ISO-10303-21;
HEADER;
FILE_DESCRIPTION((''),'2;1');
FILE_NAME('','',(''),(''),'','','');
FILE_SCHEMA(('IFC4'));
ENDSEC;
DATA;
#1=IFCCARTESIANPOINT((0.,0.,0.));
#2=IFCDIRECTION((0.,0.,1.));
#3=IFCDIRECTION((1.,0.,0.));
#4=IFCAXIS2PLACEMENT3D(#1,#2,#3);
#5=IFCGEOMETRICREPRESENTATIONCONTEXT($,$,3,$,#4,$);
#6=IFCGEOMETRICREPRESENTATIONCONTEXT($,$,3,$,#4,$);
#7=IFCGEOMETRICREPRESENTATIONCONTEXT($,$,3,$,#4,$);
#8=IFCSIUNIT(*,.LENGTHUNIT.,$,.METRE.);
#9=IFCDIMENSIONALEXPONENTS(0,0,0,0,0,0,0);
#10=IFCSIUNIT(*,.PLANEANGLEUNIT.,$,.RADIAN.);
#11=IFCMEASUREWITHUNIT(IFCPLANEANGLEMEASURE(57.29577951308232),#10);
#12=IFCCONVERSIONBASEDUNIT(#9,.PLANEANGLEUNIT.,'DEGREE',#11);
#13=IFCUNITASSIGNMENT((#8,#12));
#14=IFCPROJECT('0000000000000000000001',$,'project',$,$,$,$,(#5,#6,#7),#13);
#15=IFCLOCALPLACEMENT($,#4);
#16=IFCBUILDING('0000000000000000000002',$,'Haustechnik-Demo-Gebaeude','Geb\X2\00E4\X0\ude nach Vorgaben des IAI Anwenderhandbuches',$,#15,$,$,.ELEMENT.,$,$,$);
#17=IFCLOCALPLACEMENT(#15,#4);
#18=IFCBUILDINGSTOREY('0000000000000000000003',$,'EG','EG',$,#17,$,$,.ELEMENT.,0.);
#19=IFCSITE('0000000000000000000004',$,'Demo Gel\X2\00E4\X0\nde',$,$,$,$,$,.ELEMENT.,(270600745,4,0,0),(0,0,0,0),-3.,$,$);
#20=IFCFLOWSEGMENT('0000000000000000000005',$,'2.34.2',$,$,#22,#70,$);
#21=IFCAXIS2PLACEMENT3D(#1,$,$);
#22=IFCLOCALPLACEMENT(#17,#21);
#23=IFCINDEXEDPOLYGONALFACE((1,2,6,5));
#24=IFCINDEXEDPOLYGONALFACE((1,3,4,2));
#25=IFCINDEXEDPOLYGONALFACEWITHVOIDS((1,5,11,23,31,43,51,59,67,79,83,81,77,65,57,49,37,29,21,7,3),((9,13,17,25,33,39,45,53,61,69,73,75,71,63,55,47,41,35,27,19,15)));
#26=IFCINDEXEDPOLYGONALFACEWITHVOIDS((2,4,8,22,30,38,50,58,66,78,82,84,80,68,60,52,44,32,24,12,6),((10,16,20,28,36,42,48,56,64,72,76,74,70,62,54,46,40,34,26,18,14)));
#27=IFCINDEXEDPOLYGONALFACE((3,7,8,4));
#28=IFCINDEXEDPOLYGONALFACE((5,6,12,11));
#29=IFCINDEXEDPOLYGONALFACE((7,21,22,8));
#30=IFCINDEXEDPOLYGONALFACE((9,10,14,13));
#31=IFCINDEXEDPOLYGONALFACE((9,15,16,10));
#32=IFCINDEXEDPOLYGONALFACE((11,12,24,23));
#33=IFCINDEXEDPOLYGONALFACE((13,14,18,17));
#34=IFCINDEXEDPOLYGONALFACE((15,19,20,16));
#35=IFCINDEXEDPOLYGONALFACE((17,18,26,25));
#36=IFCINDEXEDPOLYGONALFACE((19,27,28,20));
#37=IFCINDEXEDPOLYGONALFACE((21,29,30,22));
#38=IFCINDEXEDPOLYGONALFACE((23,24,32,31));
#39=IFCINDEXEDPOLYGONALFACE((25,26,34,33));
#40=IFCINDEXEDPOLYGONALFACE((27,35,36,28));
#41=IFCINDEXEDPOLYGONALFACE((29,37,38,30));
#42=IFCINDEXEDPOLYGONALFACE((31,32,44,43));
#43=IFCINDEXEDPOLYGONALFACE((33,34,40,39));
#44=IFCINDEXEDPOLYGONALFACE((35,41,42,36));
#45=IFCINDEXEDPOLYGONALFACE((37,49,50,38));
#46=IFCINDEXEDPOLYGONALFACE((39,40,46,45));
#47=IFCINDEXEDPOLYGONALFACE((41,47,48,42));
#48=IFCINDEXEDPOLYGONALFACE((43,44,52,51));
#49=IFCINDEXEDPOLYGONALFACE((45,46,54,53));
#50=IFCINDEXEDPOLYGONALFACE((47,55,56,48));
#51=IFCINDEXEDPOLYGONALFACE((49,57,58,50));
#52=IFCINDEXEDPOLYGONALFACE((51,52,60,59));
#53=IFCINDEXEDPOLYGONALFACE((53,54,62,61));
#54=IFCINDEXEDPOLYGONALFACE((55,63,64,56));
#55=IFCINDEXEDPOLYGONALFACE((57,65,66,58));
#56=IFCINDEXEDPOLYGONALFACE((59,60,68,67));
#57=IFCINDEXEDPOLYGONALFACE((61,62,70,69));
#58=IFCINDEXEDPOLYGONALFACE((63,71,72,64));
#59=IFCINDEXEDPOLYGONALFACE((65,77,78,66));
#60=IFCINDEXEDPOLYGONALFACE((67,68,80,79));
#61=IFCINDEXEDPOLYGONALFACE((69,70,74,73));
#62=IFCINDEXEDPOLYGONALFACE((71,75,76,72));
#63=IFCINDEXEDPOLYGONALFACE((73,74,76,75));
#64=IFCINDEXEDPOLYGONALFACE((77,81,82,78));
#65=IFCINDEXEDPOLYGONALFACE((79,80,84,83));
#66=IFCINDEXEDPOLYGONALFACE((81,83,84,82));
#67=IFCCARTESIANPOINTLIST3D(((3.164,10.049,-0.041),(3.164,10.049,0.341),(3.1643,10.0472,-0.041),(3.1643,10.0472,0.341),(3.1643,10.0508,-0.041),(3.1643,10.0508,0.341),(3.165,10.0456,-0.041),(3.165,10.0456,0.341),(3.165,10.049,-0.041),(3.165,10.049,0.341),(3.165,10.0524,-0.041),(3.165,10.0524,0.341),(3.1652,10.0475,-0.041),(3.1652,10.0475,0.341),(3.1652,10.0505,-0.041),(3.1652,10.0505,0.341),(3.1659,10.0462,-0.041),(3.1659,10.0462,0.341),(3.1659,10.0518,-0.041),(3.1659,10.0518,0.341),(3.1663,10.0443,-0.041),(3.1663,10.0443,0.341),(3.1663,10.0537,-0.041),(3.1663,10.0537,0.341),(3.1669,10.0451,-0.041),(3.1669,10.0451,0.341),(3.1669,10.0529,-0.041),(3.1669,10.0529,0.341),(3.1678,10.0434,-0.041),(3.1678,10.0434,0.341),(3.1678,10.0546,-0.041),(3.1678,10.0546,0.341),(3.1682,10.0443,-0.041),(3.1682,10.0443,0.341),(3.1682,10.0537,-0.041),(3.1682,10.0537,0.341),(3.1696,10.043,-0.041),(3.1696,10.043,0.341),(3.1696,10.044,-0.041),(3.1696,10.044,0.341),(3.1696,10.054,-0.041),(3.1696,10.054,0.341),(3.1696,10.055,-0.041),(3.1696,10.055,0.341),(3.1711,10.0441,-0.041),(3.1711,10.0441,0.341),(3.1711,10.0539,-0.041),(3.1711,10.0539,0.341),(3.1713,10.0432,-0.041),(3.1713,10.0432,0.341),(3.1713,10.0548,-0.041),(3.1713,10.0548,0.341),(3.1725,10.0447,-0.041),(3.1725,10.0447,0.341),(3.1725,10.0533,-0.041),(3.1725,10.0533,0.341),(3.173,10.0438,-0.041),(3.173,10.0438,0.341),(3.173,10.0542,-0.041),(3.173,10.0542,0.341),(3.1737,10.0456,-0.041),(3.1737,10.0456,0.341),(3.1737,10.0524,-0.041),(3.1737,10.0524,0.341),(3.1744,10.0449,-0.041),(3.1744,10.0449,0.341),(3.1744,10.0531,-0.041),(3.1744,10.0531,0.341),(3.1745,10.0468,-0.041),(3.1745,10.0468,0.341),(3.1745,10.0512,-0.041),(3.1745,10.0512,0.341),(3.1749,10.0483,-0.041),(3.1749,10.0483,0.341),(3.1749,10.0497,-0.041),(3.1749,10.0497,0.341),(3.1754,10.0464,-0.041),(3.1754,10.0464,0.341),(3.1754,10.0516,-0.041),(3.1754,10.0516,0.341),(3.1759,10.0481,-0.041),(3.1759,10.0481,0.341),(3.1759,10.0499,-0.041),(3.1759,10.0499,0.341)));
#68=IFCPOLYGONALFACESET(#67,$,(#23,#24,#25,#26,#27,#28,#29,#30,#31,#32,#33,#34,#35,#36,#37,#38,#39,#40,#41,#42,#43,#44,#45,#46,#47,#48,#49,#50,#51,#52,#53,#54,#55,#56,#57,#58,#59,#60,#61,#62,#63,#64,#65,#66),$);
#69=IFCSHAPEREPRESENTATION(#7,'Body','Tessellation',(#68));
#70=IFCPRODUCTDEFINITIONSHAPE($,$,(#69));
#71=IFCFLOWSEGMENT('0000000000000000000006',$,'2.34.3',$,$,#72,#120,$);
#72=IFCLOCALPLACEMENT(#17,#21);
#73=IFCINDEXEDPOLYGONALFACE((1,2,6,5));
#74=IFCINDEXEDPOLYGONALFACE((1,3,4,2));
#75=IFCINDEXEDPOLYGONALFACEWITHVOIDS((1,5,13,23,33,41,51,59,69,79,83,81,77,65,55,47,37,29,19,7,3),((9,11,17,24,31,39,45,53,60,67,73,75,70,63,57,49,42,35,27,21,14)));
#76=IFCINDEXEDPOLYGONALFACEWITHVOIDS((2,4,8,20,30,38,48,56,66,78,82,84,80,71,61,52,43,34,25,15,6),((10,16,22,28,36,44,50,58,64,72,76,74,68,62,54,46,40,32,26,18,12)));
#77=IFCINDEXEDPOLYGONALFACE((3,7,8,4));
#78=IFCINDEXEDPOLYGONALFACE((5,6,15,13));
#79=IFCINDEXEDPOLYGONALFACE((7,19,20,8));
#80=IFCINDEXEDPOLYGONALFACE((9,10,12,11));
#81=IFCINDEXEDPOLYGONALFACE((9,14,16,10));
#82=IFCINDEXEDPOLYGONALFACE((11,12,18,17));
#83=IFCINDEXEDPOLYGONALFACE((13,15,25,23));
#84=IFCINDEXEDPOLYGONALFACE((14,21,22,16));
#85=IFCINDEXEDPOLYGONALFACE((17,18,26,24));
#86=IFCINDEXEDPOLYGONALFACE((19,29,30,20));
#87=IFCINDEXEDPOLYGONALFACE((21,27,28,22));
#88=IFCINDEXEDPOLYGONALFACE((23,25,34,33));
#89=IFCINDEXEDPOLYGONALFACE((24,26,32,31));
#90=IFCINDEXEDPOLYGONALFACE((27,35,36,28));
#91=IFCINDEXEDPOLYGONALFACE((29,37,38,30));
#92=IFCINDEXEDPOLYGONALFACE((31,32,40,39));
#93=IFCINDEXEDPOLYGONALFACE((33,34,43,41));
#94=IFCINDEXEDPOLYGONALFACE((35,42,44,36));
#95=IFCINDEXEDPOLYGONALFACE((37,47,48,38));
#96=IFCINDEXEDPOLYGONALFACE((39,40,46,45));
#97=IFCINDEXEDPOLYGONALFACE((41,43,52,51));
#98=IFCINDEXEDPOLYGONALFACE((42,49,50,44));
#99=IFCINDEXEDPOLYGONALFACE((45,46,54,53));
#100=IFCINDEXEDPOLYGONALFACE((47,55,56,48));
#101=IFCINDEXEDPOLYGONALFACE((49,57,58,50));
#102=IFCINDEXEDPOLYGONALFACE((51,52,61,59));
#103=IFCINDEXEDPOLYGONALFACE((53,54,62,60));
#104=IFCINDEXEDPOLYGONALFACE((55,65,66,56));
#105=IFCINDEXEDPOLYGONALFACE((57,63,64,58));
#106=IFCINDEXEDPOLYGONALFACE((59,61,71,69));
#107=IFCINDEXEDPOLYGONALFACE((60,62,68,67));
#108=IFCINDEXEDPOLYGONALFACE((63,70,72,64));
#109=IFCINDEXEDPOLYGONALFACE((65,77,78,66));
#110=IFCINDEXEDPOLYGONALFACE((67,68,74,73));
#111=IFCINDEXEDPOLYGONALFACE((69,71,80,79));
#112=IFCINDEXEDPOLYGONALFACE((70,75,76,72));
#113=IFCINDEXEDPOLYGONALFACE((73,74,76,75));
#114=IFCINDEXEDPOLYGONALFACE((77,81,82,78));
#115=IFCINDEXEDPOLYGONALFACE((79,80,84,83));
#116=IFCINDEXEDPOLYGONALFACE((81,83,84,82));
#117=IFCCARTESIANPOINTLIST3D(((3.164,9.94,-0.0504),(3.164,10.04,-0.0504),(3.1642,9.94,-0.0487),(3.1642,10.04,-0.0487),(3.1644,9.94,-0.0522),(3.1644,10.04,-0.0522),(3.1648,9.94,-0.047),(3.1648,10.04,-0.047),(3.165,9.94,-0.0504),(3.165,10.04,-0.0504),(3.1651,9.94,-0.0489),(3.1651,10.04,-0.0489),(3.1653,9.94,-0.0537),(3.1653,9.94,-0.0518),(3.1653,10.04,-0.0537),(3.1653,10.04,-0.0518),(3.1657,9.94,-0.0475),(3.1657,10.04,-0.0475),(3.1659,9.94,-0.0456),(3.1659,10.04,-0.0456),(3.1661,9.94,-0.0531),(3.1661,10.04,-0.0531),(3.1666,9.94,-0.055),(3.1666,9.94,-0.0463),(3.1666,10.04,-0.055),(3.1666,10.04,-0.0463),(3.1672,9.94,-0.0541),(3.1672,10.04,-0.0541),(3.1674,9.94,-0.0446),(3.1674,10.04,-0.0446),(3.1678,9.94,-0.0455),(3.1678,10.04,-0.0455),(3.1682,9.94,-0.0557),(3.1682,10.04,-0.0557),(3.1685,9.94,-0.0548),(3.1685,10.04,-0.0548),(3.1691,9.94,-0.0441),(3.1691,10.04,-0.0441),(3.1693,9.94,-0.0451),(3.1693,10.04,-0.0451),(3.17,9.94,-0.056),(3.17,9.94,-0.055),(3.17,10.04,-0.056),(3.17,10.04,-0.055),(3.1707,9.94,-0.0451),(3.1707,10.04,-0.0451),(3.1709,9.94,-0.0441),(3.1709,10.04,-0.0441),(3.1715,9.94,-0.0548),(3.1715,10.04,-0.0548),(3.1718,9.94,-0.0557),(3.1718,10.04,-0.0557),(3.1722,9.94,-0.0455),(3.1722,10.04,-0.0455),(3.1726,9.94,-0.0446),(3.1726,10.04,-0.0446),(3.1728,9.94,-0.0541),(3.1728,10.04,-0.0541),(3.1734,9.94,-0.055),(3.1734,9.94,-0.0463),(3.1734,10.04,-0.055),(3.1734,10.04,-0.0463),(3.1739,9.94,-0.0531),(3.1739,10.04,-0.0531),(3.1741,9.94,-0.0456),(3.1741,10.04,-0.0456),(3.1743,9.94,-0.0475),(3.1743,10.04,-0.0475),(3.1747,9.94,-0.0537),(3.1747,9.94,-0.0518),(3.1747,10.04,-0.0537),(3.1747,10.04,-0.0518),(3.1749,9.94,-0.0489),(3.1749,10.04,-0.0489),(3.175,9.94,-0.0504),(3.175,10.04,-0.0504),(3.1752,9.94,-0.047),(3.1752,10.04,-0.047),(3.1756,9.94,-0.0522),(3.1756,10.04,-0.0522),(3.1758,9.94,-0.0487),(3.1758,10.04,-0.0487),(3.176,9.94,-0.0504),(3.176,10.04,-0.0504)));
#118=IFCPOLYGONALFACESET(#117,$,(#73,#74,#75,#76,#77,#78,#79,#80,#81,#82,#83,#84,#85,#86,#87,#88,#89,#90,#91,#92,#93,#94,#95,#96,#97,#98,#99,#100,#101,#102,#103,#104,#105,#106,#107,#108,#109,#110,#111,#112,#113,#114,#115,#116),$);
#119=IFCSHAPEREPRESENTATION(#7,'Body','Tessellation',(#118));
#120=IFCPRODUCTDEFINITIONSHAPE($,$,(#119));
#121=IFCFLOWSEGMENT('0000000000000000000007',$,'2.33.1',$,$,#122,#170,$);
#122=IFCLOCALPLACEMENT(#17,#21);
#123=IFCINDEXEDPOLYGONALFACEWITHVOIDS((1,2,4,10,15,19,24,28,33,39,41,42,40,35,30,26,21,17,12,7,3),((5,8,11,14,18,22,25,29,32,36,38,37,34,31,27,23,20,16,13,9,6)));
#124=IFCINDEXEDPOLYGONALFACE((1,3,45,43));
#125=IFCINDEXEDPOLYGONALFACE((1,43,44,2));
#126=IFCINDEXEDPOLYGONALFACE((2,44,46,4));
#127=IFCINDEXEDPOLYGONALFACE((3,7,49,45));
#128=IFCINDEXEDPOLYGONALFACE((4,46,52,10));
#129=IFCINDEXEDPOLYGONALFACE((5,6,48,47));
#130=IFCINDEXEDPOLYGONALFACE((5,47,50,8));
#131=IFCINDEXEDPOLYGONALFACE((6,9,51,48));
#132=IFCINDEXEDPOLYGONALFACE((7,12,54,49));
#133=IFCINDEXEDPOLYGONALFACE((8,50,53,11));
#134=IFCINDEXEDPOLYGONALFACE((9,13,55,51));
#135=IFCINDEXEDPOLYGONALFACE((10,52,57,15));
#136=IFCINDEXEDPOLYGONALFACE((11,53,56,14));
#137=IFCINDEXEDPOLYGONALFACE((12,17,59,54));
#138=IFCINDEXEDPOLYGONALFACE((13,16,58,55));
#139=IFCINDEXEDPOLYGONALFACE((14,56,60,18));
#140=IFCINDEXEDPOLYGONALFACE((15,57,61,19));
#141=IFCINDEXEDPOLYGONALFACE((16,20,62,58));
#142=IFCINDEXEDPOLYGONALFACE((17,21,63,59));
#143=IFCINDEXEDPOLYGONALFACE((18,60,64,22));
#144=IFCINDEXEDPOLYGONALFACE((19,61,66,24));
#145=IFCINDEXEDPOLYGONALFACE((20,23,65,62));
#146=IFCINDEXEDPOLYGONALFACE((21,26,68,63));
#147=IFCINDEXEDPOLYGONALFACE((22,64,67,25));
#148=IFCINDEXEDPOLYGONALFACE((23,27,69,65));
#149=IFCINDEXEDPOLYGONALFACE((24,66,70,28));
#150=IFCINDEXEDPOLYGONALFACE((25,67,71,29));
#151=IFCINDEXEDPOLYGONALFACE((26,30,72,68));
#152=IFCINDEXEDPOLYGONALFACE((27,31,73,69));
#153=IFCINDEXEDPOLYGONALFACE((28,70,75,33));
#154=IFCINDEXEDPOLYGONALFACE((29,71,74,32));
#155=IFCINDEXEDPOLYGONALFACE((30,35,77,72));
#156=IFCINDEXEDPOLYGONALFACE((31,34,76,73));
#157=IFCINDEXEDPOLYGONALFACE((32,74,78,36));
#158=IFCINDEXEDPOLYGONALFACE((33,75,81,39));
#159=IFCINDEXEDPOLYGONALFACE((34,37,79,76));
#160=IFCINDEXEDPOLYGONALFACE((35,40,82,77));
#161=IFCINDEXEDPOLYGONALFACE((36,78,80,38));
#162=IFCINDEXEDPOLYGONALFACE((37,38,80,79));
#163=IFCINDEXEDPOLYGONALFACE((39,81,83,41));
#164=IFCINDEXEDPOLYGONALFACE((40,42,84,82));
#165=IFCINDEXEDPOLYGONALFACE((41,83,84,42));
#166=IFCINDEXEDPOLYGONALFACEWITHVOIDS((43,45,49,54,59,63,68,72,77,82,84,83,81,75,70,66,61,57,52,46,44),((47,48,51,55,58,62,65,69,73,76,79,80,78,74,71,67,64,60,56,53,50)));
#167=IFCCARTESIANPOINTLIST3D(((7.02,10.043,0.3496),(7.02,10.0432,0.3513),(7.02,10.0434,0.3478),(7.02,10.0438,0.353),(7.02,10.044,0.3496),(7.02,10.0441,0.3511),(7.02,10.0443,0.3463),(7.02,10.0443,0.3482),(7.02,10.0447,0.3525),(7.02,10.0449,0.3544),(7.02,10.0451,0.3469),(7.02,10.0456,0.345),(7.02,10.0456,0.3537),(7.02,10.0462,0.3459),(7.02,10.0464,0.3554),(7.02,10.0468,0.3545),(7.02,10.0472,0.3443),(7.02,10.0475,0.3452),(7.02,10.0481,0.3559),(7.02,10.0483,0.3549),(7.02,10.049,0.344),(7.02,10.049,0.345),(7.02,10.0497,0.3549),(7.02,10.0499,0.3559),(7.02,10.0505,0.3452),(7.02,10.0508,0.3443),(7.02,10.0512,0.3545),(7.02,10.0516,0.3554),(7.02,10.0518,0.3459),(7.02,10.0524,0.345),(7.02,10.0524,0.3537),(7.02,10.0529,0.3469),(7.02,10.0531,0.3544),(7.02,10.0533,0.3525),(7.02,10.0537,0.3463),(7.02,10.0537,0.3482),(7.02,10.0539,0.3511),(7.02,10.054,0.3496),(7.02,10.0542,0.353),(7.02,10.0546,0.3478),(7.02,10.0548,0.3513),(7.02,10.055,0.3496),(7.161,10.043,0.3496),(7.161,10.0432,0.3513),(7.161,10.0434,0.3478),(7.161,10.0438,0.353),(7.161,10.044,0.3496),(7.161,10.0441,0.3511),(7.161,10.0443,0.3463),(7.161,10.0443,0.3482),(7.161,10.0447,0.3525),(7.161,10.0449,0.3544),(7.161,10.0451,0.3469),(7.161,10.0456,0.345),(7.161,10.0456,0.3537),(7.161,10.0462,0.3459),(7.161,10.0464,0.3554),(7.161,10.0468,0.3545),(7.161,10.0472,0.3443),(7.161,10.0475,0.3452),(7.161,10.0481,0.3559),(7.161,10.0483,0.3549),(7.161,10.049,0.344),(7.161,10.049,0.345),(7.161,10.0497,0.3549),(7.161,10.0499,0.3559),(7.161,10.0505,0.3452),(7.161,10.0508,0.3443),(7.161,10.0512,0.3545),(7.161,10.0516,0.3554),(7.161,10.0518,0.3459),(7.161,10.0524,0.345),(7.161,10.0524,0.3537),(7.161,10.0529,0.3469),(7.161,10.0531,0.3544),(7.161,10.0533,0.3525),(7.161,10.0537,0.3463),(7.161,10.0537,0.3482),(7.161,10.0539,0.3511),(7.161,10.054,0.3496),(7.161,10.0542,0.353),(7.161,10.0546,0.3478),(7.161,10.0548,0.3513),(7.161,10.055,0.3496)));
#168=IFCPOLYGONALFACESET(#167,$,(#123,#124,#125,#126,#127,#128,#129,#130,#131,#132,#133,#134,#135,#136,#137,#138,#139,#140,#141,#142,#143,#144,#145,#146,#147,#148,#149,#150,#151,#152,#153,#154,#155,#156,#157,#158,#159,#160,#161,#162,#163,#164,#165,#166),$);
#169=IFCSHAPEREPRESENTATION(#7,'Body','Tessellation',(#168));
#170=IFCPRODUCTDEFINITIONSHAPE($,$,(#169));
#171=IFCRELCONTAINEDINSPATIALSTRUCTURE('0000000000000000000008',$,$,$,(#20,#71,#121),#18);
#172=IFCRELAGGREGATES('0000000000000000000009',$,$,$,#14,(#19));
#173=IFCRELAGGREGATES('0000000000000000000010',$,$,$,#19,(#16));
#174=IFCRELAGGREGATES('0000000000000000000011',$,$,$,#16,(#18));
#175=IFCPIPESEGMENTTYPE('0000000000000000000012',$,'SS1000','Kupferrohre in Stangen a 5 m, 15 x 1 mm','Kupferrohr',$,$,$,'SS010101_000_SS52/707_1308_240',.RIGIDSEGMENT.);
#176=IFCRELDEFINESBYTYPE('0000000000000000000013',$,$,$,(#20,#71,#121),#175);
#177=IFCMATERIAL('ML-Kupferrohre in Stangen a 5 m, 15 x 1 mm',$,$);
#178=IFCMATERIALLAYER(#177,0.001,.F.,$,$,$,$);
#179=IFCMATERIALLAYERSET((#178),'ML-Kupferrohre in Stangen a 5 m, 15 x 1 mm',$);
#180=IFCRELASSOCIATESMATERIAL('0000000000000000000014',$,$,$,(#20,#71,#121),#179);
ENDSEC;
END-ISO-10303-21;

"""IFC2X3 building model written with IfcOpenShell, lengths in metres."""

from ifc_helpers import new_model, entity, si_unit, converted_unit, frame, origin_with_axes, origin_2d_with_axis, place, context, project, spatial, hollow_circle, extrude, material, layer, layer_set, layer_usage, type_object, element, save


model = new_model("IFC2X3")

# Units and contexts
context_of_model_1 = context(None, 3, world=origin_with_axes())
context_of_model_2 = context(None, 3, world=origin_with_axes())
context_of_model_3 = context(None, 3, world=origin_with_axes())
ifc_project = project(units=[si_unit("LENGTHUNIT", "METRE"), converted_unit("PLANEANGLEUNIT", "DEGREE", entity("IfcPlaneAngleMeasure", 57.29577951308232), si_unit("PLANEANGLEUNIT", "RADIAN"), dimensions=[0, 0, 0, 0, 0, 0, 0])], contexts=[context_of_model_1, context_of_model_2, context_of_model_3])

# Site, building, storey
site = spatial("IfcSite", under=ifc_project, Name="Demo Gelände", CompositionType="ELEMENT", RefLatitude=(270600745, 4, 0, 0), RefLongitude=(0, 0, 0, 0), RefElevation=-3.0)
building_placement = place(None, origin_with_axes())
building = spatial("IfcBuilding", under=site, at=building_placement, Name="Haustechnik-Demo-Gebaeude", Description="Gebäude nach Vorgaben des IAI Anwenderhandbuches", CompositionType="ELEMENT")
storey_placement = place(building_placement, origin_with_axes())
storey = spatial("IfcBuildingStorey", under=building, at=storey_placement, Name="EG", Description="EG", CompositionType="ELEMENT", Elevation=0.0)

# Flow segments
ifc_material_1 = material(Name="ML-Kupferrohre in Stangen a 5 m, 15 x 1 mm")
ifc_layer_1 = layer(ifc_material_1, 0.001, ventilated=False)
ifc_layer_set_1 = layer_set([ifc_layer_1], Name="ML-Kupferrohre in Stangen a 5 m, 15 x 1 mm")
ifc_layer_usage_1 = layer_usage(ifc_layer_set_1, "AXIS2", "POSITIVE", 0.0)
pipe_segment_type_1 = type_object("IfcPipeSegmentType", Name="SS1000", Description="Kupferrohre in Stangen a 5 m, 15 x 1 mm", ApplicableOccurrence="Kupferrohr", ElementType="SS010101_000_SS52/707_1308_240", PredefinedType="RIGIDSEGMENT")
flow_segment_1_placement = place(storey_placement, frame((3.17, 10.049, 0.341), z_axis=(0.0, 0.0, -1.0), x_axis=(-1.0, 0.0, 0.0)))
element("IfcFlowSegment", 1, at=flow_segment_1_placement, inside=storey, type_object=pipe_segment_type_1, material=ifc_layer_usage_1, Name="2.34.2", context=context_of_model_3, shape_type="SweptSolid", body=[
    extrude(hollow_circle(Radius=0.006, WallThickness=0.001, at=origin_2d_with_axis()), origin_with_axes(), (0.0, 0.0, 1.0), 0.382),
])
flow_segment_2_placement = place(storey_placement, frame((3.17, 10.04, -0.05), z_axis=(0.000001, -1.0, 0.0), x_axis=(0.0, 0.0, -1.0)))
element("IfcFlowSegment", 2, at=flow_segment_2_placement, inside=storey, type_object=pipe_segment_type_1, material=ifc_layer_usage_1, Name="2.34.3", context=context_of_model_3, shape_type="SweptSolid", body=[
    extrude(hollow_circle(Radius=0.006, WallThickness=0.001, at=origin_2d_with_axis()), origin_with_axes(), (0.0, 0.0, 1.0), 0.1),
])
flow_segment_3_placement = place(storey_placement, frame((7.02, 10.049, 0.35), z_axis=(1.0, 0.0, 0.0), x_axis=(0.0, 0.0, -1.0)))
element("IfcFlowSegment", 3, at=flow_segment_3_placement, inside=storey, type_object=pipe_segment_type_1, material=ifc_layer_usage_1, Name="2.33.1", context=context_of_model_3, shape_type="SweptSolid", body=[
    extrude(hollow_circle(Radius=0.006, WallThickness=0.001, at=origin_2d_with_axis()), origin_with_axes(), (0.0, 0.0, 1.0), 0.141),
])

save(model, "model.ifc")
